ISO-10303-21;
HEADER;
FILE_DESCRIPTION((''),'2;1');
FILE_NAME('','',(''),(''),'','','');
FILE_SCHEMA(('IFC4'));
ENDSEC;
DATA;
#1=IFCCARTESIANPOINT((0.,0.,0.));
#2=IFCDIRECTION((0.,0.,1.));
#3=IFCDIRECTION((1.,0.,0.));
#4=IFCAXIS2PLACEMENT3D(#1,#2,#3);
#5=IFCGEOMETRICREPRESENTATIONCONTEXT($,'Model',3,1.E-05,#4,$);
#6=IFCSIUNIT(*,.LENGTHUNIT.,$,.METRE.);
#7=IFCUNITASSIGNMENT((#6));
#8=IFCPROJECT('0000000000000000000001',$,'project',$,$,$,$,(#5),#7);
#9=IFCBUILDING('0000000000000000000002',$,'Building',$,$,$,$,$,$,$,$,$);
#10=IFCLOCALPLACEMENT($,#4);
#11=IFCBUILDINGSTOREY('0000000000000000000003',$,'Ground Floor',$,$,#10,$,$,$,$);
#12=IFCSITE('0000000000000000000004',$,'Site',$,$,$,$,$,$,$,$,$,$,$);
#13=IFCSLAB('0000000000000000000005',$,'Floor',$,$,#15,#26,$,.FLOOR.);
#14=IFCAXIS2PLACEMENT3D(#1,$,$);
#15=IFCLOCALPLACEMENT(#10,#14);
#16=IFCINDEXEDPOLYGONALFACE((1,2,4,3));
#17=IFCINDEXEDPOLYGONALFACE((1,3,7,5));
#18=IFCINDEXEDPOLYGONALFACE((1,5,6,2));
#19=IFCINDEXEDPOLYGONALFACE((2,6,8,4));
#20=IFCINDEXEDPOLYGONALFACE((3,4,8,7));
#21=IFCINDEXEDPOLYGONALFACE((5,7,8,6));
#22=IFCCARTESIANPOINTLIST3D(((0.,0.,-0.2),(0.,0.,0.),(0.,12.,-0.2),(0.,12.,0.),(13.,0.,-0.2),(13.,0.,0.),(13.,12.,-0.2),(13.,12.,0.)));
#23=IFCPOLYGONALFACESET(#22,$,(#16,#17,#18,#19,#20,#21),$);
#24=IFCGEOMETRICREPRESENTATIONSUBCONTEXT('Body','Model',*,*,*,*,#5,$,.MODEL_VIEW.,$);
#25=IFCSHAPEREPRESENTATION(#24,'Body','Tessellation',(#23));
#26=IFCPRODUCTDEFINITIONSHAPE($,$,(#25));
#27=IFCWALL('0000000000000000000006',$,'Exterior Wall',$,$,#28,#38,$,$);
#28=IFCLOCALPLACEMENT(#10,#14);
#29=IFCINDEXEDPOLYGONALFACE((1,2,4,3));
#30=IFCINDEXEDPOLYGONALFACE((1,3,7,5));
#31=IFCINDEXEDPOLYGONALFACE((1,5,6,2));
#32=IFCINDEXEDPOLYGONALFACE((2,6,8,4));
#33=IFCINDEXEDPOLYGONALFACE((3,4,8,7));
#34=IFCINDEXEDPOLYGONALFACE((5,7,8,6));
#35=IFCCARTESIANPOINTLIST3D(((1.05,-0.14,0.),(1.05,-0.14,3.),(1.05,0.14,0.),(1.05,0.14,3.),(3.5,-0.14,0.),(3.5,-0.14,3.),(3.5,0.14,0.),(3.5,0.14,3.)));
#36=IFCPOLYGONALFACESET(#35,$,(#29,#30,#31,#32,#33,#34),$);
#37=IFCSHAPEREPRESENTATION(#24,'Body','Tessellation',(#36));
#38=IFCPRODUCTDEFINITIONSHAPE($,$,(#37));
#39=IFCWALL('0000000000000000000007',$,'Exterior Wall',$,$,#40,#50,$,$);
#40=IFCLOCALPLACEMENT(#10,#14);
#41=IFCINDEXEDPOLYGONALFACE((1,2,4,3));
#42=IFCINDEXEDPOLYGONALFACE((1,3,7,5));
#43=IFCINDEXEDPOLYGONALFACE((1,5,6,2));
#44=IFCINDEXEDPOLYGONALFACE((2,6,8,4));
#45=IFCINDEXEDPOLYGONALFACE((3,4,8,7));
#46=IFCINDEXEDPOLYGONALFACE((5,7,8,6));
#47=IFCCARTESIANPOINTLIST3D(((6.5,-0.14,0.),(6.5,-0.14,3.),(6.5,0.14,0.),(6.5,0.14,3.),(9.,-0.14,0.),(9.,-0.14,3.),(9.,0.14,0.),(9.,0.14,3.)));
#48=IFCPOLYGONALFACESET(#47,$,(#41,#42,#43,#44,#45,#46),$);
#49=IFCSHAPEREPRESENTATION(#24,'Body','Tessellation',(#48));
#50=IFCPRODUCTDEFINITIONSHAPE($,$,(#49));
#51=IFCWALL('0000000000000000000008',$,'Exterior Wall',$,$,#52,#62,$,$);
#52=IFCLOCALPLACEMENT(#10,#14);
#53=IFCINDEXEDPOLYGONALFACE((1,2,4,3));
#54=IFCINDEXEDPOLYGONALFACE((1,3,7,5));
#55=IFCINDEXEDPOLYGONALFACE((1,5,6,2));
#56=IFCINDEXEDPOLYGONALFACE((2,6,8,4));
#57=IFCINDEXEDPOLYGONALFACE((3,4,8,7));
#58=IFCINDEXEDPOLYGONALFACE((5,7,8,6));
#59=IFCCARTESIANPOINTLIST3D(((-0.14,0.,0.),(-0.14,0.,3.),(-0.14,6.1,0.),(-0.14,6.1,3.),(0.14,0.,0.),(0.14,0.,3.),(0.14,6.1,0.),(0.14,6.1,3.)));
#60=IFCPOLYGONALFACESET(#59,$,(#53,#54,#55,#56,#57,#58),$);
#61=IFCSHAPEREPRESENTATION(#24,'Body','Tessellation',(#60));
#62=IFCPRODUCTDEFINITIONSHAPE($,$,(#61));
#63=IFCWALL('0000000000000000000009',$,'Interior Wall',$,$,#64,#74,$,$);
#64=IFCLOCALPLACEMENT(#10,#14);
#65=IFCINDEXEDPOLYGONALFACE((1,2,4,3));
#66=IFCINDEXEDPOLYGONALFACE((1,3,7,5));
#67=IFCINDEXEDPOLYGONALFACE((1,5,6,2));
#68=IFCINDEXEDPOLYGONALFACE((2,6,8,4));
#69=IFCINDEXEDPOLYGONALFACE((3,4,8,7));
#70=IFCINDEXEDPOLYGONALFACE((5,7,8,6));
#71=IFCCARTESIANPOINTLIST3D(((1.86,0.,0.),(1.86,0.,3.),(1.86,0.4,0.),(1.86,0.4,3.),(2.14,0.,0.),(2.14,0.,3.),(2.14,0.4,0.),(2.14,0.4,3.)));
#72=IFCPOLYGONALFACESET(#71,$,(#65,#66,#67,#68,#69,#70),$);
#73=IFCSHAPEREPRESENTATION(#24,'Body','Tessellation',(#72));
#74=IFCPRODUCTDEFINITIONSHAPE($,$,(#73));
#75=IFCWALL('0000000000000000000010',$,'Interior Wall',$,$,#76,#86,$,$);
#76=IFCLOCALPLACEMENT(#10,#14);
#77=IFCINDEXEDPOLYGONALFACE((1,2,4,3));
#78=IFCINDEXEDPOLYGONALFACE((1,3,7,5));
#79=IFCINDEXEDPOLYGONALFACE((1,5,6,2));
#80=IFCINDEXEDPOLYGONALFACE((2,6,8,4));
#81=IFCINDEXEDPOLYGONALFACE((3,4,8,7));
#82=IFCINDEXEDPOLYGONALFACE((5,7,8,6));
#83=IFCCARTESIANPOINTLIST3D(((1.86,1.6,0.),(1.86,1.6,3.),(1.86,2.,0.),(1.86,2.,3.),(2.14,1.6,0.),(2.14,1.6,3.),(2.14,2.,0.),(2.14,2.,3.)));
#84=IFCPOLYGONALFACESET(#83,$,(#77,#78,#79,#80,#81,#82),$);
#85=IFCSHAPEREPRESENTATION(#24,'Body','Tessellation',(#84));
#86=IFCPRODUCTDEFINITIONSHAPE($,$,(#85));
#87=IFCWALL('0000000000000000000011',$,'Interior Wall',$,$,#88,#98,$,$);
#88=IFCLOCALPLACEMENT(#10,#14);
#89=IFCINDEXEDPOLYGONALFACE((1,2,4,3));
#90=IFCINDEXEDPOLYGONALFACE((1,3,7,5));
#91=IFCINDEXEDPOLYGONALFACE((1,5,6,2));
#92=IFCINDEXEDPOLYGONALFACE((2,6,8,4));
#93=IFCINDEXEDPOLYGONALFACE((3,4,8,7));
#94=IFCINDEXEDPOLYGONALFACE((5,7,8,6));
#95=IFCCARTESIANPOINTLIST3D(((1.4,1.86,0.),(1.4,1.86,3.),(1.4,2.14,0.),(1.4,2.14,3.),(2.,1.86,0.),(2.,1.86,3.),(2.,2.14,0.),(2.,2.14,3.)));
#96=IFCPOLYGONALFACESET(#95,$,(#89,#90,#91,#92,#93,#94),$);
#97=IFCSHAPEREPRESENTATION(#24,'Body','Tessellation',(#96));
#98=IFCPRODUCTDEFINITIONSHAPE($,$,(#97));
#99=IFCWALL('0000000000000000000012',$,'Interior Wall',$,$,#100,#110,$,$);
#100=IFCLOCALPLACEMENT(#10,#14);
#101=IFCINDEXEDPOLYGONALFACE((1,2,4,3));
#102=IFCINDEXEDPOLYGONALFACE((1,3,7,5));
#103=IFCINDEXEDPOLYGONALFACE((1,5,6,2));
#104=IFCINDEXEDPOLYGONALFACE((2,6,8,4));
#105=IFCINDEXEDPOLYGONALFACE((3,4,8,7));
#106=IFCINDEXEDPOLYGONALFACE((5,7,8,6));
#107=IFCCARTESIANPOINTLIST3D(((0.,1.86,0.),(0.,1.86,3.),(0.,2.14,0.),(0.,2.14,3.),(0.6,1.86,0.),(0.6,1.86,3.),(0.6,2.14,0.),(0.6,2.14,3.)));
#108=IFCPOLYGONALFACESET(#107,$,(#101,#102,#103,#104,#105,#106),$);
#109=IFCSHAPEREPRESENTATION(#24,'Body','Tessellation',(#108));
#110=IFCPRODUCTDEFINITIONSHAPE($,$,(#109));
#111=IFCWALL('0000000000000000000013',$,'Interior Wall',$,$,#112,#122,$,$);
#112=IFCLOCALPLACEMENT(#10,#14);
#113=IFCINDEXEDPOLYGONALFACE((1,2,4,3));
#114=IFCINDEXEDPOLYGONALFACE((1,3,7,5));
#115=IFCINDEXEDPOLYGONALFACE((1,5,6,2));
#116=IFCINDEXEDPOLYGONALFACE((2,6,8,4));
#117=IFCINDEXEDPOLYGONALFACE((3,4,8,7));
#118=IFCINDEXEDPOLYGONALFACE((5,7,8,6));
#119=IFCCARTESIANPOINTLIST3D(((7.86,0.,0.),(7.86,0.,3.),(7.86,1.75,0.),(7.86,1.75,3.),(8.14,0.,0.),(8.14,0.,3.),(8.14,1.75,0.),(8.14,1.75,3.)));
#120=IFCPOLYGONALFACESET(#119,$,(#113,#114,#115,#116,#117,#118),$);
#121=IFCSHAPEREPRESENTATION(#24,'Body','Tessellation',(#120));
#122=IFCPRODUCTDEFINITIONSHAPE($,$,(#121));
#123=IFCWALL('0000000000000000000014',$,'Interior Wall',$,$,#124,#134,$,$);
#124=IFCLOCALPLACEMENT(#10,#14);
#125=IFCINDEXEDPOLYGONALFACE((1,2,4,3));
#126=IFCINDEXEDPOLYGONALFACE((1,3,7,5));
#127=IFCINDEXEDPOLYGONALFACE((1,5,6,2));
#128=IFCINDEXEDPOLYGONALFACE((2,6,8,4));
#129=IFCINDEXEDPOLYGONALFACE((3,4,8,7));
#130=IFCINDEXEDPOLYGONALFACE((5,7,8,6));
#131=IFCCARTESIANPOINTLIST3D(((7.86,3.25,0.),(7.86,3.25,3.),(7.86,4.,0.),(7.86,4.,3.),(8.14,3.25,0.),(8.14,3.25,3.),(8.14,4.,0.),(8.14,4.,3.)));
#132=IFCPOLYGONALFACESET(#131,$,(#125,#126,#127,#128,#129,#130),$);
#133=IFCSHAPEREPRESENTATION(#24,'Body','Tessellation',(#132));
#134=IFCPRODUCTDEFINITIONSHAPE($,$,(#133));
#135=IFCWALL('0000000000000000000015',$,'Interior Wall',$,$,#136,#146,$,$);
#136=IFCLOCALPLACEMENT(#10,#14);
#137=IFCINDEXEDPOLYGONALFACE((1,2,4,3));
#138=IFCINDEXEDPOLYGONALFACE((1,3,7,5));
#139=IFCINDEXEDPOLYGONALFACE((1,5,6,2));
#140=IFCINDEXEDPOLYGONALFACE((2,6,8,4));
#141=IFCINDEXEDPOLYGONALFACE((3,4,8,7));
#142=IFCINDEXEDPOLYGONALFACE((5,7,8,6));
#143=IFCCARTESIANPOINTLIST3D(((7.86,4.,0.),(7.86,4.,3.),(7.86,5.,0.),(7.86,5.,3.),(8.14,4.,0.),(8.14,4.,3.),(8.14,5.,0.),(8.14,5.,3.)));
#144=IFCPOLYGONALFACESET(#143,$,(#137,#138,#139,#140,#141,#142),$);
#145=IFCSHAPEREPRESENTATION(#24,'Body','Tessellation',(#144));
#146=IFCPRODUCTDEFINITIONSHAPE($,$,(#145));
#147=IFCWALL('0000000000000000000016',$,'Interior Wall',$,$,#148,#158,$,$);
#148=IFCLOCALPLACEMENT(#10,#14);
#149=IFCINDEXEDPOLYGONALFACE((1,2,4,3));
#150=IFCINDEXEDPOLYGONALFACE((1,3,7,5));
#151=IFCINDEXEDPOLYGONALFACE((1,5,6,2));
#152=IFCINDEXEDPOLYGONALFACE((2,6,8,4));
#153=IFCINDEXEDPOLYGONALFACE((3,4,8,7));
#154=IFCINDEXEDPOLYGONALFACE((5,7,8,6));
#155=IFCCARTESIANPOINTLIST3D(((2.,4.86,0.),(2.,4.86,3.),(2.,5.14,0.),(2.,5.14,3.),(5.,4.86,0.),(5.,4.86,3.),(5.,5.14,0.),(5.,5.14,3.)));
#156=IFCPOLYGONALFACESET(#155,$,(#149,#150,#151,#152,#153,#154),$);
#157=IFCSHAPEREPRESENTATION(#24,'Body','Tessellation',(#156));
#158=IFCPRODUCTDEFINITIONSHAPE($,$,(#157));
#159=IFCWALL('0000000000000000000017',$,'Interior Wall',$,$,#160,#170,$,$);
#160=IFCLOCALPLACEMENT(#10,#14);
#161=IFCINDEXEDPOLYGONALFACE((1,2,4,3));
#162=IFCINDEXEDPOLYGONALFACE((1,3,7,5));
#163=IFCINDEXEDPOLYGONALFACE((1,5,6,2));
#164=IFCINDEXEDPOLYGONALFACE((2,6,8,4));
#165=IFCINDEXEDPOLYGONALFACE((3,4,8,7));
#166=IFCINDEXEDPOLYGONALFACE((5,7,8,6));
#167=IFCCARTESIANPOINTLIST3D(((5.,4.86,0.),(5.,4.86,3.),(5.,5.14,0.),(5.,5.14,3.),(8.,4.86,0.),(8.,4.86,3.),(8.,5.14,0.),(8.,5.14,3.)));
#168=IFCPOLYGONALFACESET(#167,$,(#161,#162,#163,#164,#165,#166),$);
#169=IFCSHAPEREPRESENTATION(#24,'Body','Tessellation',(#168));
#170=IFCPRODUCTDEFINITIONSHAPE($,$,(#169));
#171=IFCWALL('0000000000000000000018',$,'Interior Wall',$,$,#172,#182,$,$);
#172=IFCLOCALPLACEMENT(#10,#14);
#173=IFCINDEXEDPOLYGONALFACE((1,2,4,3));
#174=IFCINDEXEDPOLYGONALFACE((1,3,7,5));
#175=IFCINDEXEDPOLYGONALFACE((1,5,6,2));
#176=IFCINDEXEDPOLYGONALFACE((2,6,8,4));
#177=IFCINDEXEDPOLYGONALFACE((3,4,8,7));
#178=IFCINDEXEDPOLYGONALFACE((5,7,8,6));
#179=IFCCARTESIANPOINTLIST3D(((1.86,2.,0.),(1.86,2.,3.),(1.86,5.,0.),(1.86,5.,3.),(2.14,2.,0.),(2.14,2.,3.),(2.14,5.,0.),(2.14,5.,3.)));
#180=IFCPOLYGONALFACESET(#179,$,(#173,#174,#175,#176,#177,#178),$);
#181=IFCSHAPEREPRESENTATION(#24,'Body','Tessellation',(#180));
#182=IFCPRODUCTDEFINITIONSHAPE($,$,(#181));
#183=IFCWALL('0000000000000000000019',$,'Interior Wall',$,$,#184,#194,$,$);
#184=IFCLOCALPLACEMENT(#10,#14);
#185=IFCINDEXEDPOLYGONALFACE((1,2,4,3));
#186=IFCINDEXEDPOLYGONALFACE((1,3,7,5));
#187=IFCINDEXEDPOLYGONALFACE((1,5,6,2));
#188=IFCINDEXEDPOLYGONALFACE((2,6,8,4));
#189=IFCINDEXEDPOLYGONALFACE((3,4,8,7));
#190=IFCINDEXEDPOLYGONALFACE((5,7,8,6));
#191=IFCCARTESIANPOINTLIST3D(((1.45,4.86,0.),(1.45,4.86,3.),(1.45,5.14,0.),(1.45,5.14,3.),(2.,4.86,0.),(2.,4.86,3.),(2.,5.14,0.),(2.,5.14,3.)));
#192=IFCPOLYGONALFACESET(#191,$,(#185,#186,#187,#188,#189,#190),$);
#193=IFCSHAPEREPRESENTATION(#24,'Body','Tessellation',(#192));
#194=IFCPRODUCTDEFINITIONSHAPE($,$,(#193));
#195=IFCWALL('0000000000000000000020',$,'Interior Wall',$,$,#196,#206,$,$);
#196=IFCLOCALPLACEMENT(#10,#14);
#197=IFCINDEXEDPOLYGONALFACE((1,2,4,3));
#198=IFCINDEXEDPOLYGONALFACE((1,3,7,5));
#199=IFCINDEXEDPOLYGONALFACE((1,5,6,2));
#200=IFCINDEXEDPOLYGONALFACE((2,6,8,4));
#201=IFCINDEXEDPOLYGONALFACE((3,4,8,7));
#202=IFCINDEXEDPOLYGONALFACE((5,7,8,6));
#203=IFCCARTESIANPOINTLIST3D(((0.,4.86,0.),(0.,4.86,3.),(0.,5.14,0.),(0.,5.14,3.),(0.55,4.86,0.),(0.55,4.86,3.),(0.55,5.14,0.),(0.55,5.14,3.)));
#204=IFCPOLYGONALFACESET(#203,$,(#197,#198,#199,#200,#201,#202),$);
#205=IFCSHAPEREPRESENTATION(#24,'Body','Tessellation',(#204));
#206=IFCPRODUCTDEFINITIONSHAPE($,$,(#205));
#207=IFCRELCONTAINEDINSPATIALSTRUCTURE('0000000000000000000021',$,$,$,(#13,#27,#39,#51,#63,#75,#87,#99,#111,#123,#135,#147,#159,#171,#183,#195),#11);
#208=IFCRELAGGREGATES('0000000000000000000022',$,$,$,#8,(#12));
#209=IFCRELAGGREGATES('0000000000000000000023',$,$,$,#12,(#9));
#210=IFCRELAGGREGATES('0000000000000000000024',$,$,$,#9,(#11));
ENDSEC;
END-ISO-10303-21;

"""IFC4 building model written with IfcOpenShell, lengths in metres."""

from ifc_helpers import new_model, si_unit, frame, origin_with_axes, place, context, subcontext, project, spatial, indexed_curve, outline, extrude, element, save


model = new_model("IFC4")

# Units and contexts
model_context = context("Model", 3, precision=1e-05, world=origin_with_axes())
body_context = subcontext(model_context, "Body", "Model", "MODEL_VIEW")
ifc_project = project(units=[si_unit("LENGTHUNIT", "METRE")], contexts=[model_context])

# Site, building, storey
site = spatial("IfcSite", under=ifc_project, Name="Site")
building = spatial("IfcBuilding", under=site, Name="Building")
storey_placement = place(None, origin_with_axes())
storey = spatial("IfcBuildingStorey", under=building, at=storey_placement, Name="Ground Floor")

# Slab
slab_placement = place(storey_placement, frame((0.0, 0.0, -0.2), z_axis=(0.0, 0.0, 1.0), x_axis=(1.0, 0.0, 0.0)))
element("IfcSlab", 1, at=slab_placement, inside=storey, Name="Floor", PredefinedType="FLOOR", context=body_context, shape_type="SweptSolid", body=[
    extrude(outline(indexed_curve([(0.0, 0.0), (13.0, 0.0), (13.0, 12.0), (0.0, 12.0)])), None, (0.0, 0.0, 1.0), 0.2),
])

# Walls
wall_1_placement = place(storey_placement, frame((1.05, 0.0, 0.0), z_axis=(0.0, 0.0, 1.0), x_axis=(1.0, 0.0, 0.0)))
element("IfcWall", 2, at=wall_1_placement, inside=storey, Name="Exterior Wall", context=body_context, shape_type="SweptSolid", body=[
    extrude(outline(indexed_curve([(0.0, 0.0), (0.0, 0.28), (2.45, 0.28), (2.45, 0.0), (0.0, 0.0)], self_intersect=False)), frame((0.0, -0.14, 0.0), z_axis=(0.0, 0.0, 1.0), x_axis=(1.0, 0.0, 0.0)), (0.0, 0.0, 1.0), 3.0),
])
wall_2_placement = place(storey_placement, frame((6.5, 0.0, 0.0), z_axis=(0.0, 0.0, 1.0), x_axis=(1.0, 0.0, 0.0)))
element("IfcWall", 3, at=wall_2_placement, inside=storey, Name="Exterior Wall", context=body_context, shape_type="SweptSolid", body=[
    extrude(outline(indexed_curve([(0.0, 0.0), (0.0, 0.28), (2.5, 0.28), (2.5, 0.0), (0.0, 0.0)], self_intersect=False)), frame((0.0, -0.14, 0.0), z_axis=(0.0, 0.0, 1.0), x_axis=(1.0, 0.0, 0.0)), (0.0, 0.0, 1.0), 3.0),
])
wall_3_placement = place(storey_placement, frame((0.0, 6.1, 0.0), z_axis=(0.0, 0.0, 1.0), x_axis=(0.0, -1.0, 0.0)))
element("IfcWall", 4, at=wall_3_placement, inside=storey, Name="Exterior Wall", context=body_context, shape_type="SweptSolid", body=[
    extrude(outline(indexed_curve([(0.0, 0.0), (0.0, 0.28), (6.1, 0.28), (6.1, 0.0), (0.0, 0.0)], self_intersect=False)), frame((0.0, -0.14, 0.0), z_axis=(0.0, 0.0, 1.0), x_axis=(1.0, 0.0, 0.0)), (0.0, 0.0, 1.0), 3.0),
])
wall_4_placement = place(storey_placement, frame((2.0, 0.0, 0.0), z_axis=(0.0, 0.0, 1.0), x_axis=(0.0, 1.0, 0.0)))
element("IfcWall", 5, at=wall_4_placement, inside=storey, Name="Interior Wall", context=body_context, shape_type="SweptSolid", body=[
    extrude(outline(indexed_curve([(0.0, 0.0), (0.0, 0.28), (0.4, 0.28), (0.4, 0.0), (0.0, 0.0)], self_intersect=False)), frame((0.0, -0.14, 0.0), z_axis=(0.0, 0.0, 1.0), x_axis=(1.0, 0.0, 0.0)), (0.0, 0.0, 1.0), 3.0),
])
wall_5_placement = place(storey_placement, frame((2.0, 1.6, 0.0), z_axis=(0.0, 0.0, 1.0), x_axis=(0.0, 1.0, 0.0)))
element("IfcWall", 6, at=wall_5_placement, inside=storey, Name="Interior Wall", context=body_context, shape_type="SweptSolid", body=[
    extrude(outline(indexed_curve([(0.0, 0.0), (0.0, 0.28), (0.4, 0.28), (0.4, 0.0), (0.0, 0.0)], self_intersect=False)), frame((0.0, -0.14, 0.0), z_axis=(0.0, 0.0, 1.0), x_axis=(1.0, 0.0, 0.0)), (0.0, 0.0, 1.0), 3.0),
])
for number, where, z_axis, x_axis, name in (
    (7, (2.0, 2.0, 0.0), (0.0, 0.0, 1.0), (-1.0, 0.0, 0.0), "Interior Wall"),
    (8, (0.6, 2.0, 0.0), (0.0, 0.0, 1.0), (-1.0, 0.0, 0.0), "Interior Wall"),
):
    element("IfcWall", number, at=place(storey_placement, frame(where, z_axis=z_axis, x_axis=x_axis)), inside=storey, Name=name, context=body_context, shape_type="SweptSolid", body=[
        extrude(outline(indexed_curve([(0.0, 0.0), (0.0, 0.28), (0.6, 0.28), (0.6, 0.0), (0.0, 0.0)], self_intersect=False)), frame((0.0, -0.14, 0.0), z_axis=(0.0, 0.0, 1.0), x_axis=(1.0, 0.0, 0.0)), (0.0, 0.0, 1.0), 3.0),
    ])
wall_6_placement = place(storey_placement, frame((8.0, 0.0, 0.0), z_axis=(0.0, 0.0, 1.0), x_axis=(0.0, 1.0, 0.0)))
element("IfcWall", 9, at=wall_6_placement, inside=storey, Name="Interior Wall", context=body_context, shape_type="SweptSolid", body=[
    extrude(outline(indexed_curve([(0.0, 0.0), (0.0, 0.28), (1.75, 0.28), (1.75, 0.0), (0.0, 0.0)], self_intersect=False)), frame((0.0, -0.14, 0.0), z_axis=(0.0, 0.0, 1.0), x_axis=(1.0, 0.0, 0.0)), (0.0, 0.0, 1.0), 3.0),
])
wall_7_placement = place(storey_placement, frame((8.0, 3.25, 0.0), z_axis=(0.0, 0.0, 1.0), x_axis=(0.0, 1.0, 0.0)))
element("IfcWall", 10, at=wall_7_placement, inside=storey, Name="Interior Wall", context=body_context, shape_type="SweptSolid", body=[
    extrude(outline(indexed_curve([(0.0, 0.0), (0.0, 0.28), (0.75, 0.28), (0.75, 0.0), (0.0, 0.0)], self_intersect=False)), frame((0.0, -0.14, 0.0), z_axis=(0.0, 0.0, 1.0), x_axis=(1.0, 0.0, 0.0)), (0.0, 0.0, 1.0), 3.0),
])
wall_8_placement = place(storey_placement, frame((8.0, 4.0, 0.0), z_axis=(0.0, 0.0, 1.0), x_axis=(0.0, 1.0, 0.0)))
element("IfcWall", 11, at=wall_8_placement, inside=storey, Name="Interior Wall", context=body_context, shape_type="SweptSolid", body=[
    extrude(outline(indexed_curve([(0.0, 0.0), (0.0, 0.28), (1.0, 0.28), (1.0, 0.0), (0.0, 0.0)], self_intersect=False)), frame((0.0, -0.14, 0.0), z_axis=(0.0, 0.0, 1.0), x_axis=(1.0, 0.0, 0.0)), (0.0, 0.0, 1.0), 3.0),
])
for number, where, z_axis, x_axis, name in (
    (12, (5.0, 5.0, 0.0), (0.0, 0.0, 1.0), (-1.0, 0.0, 0.0), "Interior Wall"),
    (13, (8.0, 5.0, 0.0), (0.0, 0.0, 1.0), (-1.0, 0.0, 0.0), "Interior Wall"),
    (14, (2.0, 5.0, 0.0), (0.0, 0.0, 1.0), (0.0, -1.0, 0.0), "Interior Wall"),
):
    element("IfcWall", number, at=place(storey_placement, frame(where, z_axis=z_axis, x_axis=x_axis)), inside=storey, Name=name, context=body_context, shape_type="SweptSolid", body=[
        extrude(outline(indexed_curve([(0.0, 0.0), (0.0, 0.28), (3.0, 0.28), (3.0, 0.0), (0.0, 0.0)], self_intersect=False)), frame((0.0, -0.14, 0.0), z_axis=(0.0, 0.0, 1.0), x_axis=(1.0, 0.0, 0.0)), (0.0, 0.0, 1.0), 3.0),
    ])
for number, where, z_axis, x_axis, name in (
    (15, (2.0, 5.0, 0.0), (0.0, 0.0, 1.0), (-1.0, 0.0, 0.0), "Interior Wall"),
    (16, (0.55, 5.0, 0.0), (0.0, 0.0, 1.0), (-1.0, 0.0, 0.0), "Interior Wall"),
):
    element("IfcWall", number, at=place(storey_placement, frame(where, z_axis=z_axis, x_axis=x_axis)), inside=storey, Name=name, context=body_context, shape_type="SweptSolid", body=[
        extrude(outline(indexed_curve([(0.0, 0.0), (0.0, 0.28), (0.55, 0.28), (0.55, 0.0), (0.0, 0.0)], self_intersect=False)), frame((0.0, -0.14, 0.0), z_axis=(0.0, 0.0, 1.0), x_axis=(1.0, 0.0, 0.0)), (0.0, 0.0, 1.0), 3.0),
    ])

save(model, "model.ifc")
